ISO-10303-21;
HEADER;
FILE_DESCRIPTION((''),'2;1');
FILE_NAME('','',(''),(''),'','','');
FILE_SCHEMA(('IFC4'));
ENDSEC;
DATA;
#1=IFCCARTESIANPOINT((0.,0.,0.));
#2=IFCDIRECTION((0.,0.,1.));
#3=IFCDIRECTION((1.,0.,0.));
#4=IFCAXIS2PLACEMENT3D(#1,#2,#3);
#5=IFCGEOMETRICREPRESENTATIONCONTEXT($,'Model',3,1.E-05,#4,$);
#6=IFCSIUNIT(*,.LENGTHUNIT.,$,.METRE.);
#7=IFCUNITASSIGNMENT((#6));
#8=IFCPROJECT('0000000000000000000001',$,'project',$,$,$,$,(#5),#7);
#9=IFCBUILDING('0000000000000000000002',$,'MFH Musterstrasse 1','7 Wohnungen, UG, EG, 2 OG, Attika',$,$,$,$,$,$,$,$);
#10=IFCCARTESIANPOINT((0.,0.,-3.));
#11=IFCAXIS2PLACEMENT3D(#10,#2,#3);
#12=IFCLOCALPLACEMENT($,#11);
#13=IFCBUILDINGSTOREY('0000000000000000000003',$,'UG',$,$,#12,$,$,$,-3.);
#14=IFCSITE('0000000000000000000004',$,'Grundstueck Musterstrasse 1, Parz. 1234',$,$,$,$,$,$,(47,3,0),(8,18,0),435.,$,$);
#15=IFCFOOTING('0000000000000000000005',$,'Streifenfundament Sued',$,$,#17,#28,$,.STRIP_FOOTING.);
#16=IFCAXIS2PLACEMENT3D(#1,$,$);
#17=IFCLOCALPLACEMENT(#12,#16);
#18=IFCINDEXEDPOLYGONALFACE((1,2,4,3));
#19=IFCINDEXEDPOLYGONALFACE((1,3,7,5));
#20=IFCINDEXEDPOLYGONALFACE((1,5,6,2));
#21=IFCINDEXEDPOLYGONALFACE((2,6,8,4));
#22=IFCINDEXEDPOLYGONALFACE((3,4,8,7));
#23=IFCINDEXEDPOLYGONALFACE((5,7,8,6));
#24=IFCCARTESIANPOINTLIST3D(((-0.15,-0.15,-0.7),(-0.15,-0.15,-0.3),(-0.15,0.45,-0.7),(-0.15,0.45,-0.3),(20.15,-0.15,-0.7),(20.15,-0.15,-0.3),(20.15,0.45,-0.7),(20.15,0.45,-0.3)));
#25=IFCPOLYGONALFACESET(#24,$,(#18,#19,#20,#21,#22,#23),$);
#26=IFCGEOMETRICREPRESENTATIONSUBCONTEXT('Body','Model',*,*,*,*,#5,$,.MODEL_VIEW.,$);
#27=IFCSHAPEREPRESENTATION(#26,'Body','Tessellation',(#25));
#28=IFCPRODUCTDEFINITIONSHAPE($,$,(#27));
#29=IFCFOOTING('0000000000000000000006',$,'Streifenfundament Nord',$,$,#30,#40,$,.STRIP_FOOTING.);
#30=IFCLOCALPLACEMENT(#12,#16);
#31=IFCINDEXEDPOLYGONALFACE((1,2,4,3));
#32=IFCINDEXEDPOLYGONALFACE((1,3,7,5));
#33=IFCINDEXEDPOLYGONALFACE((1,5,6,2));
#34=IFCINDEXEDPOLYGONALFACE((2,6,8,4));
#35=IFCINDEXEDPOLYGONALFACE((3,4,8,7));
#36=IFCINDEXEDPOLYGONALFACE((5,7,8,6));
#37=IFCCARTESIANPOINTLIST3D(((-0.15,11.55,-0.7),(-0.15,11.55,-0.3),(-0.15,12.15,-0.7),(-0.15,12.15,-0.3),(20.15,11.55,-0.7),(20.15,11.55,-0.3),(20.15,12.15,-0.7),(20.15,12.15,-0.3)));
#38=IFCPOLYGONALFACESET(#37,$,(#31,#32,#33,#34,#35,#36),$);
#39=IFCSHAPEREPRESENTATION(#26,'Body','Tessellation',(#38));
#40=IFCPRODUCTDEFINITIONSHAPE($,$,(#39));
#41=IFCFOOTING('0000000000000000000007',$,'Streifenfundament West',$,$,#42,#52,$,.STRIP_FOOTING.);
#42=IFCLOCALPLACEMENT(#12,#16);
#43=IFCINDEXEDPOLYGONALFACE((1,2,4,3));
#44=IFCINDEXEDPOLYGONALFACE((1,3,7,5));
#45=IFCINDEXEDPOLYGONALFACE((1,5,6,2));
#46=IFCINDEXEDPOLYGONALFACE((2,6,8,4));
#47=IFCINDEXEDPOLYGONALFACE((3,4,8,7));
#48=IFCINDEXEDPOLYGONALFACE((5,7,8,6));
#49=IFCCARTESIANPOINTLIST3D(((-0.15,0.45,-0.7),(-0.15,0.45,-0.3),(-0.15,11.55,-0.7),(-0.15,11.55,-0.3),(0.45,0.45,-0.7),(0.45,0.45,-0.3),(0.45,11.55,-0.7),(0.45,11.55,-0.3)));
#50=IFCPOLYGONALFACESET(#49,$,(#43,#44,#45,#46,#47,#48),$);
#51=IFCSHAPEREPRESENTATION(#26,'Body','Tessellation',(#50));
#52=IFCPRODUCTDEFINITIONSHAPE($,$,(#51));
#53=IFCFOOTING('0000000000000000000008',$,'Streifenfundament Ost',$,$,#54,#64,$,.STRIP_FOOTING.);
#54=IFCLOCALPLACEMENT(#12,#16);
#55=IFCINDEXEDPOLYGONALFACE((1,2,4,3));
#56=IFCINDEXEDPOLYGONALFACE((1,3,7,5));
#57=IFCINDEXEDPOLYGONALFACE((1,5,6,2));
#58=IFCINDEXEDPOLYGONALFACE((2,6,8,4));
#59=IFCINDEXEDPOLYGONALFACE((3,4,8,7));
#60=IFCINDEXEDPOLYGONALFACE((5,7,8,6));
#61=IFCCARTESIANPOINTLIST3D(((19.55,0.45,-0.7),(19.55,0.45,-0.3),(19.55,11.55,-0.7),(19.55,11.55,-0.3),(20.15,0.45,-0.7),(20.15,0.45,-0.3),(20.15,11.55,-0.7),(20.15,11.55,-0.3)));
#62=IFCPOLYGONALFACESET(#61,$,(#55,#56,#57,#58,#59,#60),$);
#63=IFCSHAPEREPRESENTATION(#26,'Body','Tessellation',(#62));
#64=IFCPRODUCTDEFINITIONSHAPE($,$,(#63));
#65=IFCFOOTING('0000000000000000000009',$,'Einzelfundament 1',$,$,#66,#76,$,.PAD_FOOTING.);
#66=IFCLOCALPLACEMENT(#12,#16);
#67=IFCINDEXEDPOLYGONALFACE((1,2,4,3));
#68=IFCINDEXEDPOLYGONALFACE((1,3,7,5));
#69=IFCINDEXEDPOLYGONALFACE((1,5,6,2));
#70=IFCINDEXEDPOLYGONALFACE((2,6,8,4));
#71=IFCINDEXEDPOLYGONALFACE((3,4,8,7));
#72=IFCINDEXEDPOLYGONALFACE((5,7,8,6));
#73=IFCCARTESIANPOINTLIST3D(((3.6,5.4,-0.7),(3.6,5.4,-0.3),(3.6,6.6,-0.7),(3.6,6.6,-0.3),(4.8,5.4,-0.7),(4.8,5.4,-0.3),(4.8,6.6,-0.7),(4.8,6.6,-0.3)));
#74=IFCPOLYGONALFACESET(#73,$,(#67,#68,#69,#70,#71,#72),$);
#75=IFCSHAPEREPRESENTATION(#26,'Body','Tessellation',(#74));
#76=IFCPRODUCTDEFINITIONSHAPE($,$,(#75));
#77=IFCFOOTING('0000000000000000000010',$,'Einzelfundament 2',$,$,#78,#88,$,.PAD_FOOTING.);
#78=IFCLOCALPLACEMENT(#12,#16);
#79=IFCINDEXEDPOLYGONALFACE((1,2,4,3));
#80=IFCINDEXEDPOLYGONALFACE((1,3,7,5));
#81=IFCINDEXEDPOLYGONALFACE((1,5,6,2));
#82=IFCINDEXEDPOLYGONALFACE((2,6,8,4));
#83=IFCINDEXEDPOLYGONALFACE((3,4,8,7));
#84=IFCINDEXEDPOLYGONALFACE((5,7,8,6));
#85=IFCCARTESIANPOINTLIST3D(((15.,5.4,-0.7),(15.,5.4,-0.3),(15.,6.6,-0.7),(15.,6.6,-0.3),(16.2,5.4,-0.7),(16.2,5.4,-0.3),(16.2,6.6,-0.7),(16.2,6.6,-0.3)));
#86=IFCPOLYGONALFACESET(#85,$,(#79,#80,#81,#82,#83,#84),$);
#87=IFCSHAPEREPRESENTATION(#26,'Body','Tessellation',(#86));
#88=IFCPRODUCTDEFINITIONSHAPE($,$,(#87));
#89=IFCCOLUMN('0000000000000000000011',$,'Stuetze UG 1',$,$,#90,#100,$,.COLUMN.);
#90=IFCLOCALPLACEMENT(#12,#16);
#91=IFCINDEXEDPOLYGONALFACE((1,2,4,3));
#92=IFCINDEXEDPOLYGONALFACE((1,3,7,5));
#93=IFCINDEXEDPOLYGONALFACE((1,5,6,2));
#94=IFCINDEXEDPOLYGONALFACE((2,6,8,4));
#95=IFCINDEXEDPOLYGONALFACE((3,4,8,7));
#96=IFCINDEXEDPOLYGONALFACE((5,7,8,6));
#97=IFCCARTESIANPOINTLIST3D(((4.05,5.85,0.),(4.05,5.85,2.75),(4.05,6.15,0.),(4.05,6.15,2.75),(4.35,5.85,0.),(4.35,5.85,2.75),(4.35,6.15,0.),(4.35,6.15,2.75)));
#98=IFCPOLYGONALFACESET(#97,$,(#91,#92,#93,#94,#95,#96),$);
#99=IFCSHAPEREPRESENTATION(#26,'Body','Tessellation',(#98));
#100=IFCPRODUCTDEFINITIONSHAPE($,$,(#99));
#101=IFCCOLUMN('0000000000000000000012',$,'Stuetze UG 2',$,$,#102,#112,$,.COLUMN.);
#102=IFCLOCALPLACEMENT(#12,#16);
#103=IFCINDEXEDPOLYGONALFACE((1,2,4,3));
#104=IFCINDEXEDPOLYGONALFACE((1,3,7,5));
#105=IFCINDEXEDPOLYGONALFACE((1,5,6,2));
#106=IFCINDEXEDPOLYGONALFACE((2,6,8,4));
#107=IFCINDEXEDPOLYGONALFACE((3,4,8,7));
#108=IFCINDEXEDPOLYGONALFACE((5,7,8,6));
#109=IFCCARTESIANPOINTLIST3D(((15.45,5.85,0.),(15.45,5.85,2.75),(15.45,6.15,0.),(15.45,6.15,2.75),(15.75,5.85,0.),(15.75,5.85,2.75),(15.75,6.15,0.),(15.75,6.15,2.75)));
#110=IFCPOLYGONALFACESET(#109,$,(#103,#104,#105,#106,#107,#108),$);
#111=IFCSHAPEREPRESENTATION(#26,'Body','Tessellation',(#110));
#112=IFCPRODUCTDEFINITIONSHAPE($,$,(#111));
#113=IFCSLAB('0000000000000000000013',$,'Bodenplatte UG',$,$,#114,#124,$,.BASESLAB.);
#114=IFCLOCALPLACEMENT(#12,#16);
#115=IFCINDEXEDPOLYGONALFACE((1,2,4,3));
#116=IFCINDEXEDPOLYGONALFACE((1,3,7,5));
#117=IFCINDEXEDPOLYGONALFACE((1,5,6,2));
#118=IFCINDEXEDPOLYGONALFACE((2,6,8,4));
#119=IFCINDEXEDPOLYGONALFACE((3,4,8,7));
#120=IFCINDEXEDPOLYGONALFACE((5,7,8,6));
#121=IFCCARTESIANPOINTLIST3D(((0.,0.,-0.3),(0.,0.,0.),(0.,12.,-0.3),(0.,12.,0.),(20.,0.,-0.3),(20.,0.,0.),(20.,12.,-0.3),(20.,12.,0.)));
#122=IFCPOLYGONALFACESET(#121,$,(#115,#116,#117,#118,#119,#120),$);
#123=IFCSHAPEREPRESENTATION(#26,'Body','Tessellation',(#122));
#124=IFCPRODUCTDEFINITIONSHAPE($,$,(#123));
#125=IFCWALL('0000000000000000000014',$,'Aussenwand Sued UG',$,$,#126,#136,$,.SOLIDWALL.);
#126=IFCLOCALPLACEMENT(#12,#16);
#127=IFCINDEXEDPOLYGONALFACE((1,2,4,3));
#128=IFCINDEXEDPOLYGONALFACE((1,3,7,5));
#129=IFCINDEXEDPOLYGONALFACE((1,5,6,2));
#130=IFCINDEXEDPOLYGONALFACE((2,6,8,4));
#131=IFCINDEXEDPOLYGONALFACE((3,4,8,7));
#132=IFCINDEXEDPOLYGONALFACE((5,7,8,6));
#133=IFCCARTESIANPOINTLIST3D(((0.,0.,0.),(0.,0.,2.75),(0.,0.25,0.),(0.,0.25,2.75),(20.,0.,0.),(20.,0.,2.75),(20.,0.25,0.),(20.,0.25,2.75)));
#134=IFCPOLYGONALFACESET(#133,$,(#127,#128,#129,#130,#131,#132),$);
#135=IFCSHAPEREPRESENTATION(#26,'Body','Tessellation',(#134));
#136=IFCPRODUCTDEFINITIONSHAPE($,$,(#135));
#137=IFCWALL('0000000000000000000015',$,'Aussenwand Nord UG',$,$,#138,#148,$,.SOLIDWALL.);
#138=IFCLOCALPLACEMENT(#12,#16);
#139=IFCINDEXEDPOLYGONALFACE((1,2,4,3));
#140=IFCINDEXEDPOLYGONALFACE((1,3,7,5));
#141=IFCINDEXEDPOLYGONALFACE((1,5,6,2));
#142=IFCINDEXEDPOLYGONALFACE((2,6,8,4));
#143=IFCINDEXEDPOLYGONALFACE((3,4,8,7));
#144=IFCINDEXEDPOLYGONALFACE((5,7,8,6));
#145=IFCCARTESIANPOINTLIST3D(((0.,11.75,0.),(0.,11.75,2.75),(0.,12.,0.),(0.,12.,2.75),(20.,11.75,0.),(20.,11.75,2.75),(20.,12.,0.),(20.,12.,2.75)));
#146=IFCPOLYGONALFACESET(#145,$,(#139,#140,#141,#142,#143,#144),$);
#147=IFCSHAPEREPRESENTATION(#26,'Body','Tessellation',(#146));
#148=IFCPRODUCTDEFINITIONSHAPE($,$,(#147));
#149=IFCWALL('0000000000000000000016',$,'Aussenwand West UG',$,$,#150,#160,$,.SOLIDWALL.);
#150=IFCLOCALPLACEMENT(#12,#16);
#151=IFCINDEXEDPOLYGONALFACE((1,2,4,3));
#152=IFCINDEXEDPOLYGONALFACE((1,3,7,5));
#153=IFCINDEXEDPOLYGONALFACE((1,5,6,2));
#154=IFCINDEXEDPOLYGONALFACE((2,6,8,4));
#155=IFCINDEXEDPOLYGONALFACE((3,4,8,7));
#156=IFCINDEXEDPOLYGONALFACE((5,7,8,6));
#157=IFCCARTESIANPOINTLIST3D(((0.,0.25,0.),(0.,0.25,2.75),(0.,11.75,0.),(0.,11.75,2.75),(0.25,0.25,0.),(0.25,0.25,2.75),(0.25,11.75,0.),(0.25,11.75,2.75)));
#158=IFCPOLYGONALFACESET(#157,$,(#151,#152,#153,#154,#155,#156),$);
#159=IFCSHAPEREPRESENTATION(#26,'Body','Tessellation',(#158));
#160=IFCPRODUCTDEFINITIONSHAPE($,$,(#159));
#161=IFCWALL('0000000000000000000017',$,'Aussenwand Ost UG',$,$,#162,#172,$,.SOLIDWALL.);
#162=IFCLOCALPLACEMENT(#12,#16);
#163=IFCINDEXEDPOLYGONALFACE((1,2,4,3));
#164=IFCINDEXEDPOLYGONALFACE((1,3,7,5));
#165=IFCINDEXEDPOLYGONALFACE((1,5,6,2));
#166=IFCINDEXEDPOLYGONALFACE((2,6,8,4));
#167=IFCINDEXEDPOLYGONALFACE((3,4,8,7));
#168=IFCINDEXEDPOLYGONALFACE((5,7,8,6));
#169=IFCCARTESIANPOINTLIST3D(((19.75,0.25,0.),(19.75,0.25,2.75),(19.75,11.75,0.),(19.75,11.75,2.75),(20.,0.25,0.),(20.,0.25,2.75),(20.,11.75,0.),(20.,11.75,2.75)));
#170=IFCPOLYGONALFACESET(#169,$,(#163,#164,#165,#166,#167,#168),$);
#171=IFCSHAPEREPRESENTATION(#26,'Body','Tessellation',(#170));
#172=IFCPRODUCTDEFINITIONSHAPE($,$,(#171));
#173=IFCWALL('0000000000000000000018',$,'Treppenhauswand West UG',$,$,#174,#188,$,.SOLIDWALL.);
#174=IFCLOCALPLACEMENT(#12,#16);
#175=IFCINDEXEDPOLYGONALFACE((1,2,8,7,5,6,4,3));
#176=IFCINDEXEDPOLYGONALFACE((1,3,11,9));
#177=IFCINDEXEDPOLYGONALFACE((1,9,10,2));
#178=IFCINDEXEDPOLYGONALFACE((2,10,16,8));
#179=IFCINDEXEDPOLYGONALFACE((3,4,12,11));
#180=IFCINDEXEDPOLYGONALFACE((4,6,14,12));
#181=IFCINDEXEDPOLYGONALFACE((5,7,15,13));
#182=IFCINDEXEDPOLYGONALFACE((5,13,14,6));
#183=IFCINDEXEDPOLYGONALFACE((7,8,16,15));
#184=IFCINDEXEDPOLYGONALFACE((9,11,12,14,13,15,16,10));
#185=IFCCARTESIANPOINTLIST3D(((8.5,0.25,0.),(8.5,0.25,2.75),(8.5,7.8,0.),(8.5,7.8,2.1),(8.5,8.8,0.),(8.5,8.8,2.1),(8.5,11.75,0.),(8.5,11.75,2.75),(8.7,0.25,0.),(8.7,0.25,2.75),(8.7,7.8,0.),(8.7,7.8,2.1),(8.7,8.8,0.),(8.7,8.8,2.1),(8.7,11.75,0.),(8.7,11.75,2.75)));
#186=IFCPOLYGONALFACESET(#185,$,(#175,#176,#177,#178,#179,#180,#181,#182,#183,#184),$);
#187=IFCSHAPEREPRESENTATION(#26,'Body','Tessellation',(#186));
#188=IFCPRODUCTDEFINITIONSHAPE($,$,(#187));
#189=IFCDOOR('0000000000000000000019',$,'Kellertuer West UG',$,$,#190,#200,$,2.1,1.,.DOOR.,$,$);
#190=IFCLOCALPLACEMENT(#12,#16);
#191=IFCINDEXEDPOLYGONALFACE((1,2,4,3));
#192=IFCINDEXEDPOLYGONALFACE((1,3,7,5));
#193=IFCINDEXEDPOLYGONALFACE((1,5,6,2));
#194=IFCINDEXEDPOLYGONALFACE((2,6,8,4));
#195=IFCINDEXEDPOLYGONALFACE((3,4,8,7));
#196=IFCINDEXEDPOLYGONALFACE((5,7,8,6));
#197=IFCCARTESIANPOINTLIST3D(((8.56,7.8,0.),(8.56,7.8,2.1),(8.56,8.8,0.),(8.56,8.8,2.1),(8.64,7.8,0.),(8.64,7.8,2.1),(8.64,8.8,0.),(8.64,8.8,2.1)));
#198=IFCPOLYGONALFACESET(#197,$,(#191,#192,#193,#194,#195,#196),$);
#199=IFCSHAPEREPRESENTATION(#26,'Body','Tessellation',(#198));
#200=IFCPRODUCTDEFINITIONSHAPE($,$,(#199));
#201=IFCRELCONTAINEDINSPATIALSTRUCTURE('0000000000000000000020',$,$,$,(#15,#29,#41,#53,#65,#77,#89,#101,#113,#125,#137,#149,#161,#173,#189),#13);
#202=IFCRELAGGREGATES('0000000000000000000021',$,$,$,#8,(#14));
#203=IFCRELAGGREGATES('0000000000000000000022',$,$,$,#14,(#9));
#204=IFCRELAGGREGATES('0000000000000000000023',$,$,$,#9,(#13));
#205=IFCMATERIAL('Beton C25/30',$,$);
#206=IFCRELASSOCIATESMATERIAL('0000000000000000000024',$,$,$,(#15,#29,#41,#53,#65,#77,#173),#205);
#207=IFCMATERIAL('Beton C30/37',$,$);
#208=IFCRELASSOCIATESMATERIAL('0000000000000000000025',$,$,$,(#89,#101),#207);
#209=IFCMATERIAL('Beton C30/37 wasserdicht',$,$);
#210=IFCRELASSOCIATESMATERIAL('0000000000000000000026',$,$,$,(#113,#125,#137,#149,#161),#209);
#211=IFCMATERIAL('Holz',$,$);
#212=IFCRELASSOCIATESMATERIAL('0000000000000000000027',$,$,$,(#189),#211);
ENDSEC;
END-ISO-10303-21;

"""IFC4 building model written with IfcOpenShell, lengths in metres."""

from ifc_helpers import new_model, si_unit, frame, frame_2d, origin_with_axes, place, context, subcontext, project, spatial, polyline, rectangle, outline, extrude, material, element, fill, save


model = new_model("IFC4")

# Units and contexts
model_context = context("Model", 3, precision=1e-05, world=origin_with_axes())
body_context = subcontext(model_context, "Body", "Model", "MODEL_VIEW")
ifc_project = project(units=[si_unit("LENGTHUNIT", "METRE")], contexts=[model_context])

# Site, building, storey
site = spatial("IfcSite", under=ifc_project, Name="Grundstueck Musterstrasse 1, Parz. 1234", RefLatitude=(47, 3, 0), RefLongitude=(8, 18, 0), RefElevation=435.0)
building = spatial("IfcBuilding", under=site, Name="MFH Musterstrasse 1", Description="7 Wohnungen, UG, EG, 2 OG, Attika")
storey_placement = place(None, frame((0.0, 0.0, -3.0), z_axis=(0.0, 0.0, 1.0), x_axis=(1.0, 0.0, 0.0)))
storey = spatial("IfcBuildingStorey", under=building, at=storey_placement, Name="UG", Elevation=-3.0)

# Footings
ifc_material_1 = material(Name="Beton C25/30")
for number, where, z_axis, x_axis, name in (
    (1, (-0.15, -0.15, -0.7), (0.0, 0.0, 1.0), (1.0, 0.0, 0.0), "Streifenfundament Sued"),
    (2, (-0.15, 11.55, -0.7), (0.0, 0.0, 1.0), (1.0, 0.0, 0.0), "Streifenfundament Nord"),
):
    element("IfcFooting", number, at=place(storey_placement, frame(where, z_axis=z_axis, x_axis=x_axis)), inside=storey, material=ifc_material_1, Name=name, PredefinedType="STRIP_FOOTING", context=body_context, shape_type="SweptSolid", body=[
        extrude(rectangle(XDim=20.3, YDim=0.6, at=frame_2d((10.15, 0.3))), origin_with_axes(), (0.0, 0.0, 1.0), 0.4),
    ])
for number, where, z_axis, x_axis, name in (
    (3, (-0.15, 0.45, -0.7), (0.0, 0.0, 1.0), (1.0, 0.0, 0.0), "Streifenfundament West"),
    (4, (19.55, 0.45, -0.7), (0.0, 0.0, 1.0), (1.0, 0.0, 0.0), "Streifenfundament Ost"),
):
    element("IfcFooting", number, at=place(storey_placement, frame(where, z_axis=z_axis, x_axis=x_axis)), inside=storey, material=ifc_material_1, Name=name, PredefinedType="STRIP_FOOTING", context=body_context, shape_type="SweptSolid", body=[
        extrude(rectangle(XDim=0.6, YDim=11.1, at=frame_2d((0.3, 5.55))), origin_with_axes(), (0.0, 0.0, 1.0), 0.4),
    ])
for number, where, z_axis, x_axis, name in (
    (5, (3.6, 5.4, -0.7), (0.0, 0.0, 1.0), (1.0, 0.0, 0.0), "Einzelfundament 1"),
    (6, (15.0, 5.4, -0.7), (0.0, 0.0, 1.0), (1.0, 0.0, 0.0), "Einzelfundament 2"),
):
    element("IfcFooting", number, at=place(storey_placement, frame(where, z_axis=z_axis, x_axis=x_axis)), inside=storey, material=ifc_material_1, Name=name, PredefinedType="PAD_FOOTING", context=body_context, shape_type="SweptSolid", body=[
        extrude(rectangle(XDim=1.2, YDim=1.2, at=frame_2d((0.6, 0.6))), origin_with_axes(), (0.0, 0.0, 1.0), 0.4),
    ])

# Columns
ifc_material_2 = material(Name="Beton C30/37")
for number, where, z_axis, x_axis, name in (
    (7, (4.05, 5.85, 0.0), (0.0, 0.0, 1.0), (1.0, 0.0, 0.0), "Stuetze UG 1"),
    (8, (15.45, 5.85, 0.0), (0.0, 0.0, 1.0), (1.0, 0.0, 0.0), "Stuetze UG 2"),
):
    element("IfcColumn", number, at=place(storey_placement, frame(where, z_axis=z_axis, x_axis=x_axis)), inside=storey, material=ifc_material_2, Name=name, PredefinedType="COLUMN", context=body_context, shape_type="SweptSolid", body=[
        extrude(rectangle(XDim=0.3, YDim=0.3, at=frame_2d((0.15, 0.15))), origin_with_axes(), (0.0, 0.0, 1.0), 2.75),
    ])

# Slab
ifc_material_3 = material(Name="Beton C30/37 wasserdicht")
slab_placement = place(storey_placement, frame((0.0, 0.0, -0.3), z_axis=(0.0, 0.0, 1.0), x_axis=(1.0, 0.0, 0.0)))
element("IfcSlab", 9, at=slab_placement, inside=storey, material=ifc_material_3, Name="Bodenplatte UG", PredefinedType="BASESLAB", context=body_context, shape_type="SweptSolid", body=[
    extrude(outline(polyline([(0.0, 0.0), (20.0, 0.0), (20.0, 12.0), (0.0, 12.0), (0.0, 0.0)])), origin_with_axes(), (0.0, 0.0, 1.0), 0.3),
])

# Walls
for number, where, z_axis, x_axis, name in (
    (10, (0.0, 0.0, 0.0), (0.0, 0.0, 1.0), (1.0, 0.0, 0.0), "Aussenwand Sued UG"),
    (11, (0.0, 11.75, 0.0), (0.0, 0.0, 1.0), (1.0, 0.0, 0.0), "Aussenwand Nord UG"),
):
    element("IfcWall", number, at=place(storey_placement, frame(where, z_axis=z_axis, x_axis=x_axis)), inside=storey, material=ifc_material_3, Name=name, PredefinedType="SOLIDWALL", context=body_context, shape_type="SweptSolid", body=[
        extrude(rectangle(XDim=20.0, YDim=0.25, at=frame_2d((10.0, 0.125))), origin_with_axes(), (0.0, 0.0, 1.0), 2.75),
    ])
for number, where, z_axis, x_axis, name in (
    (12, (0.0, 0.25, 0.0), (0.0, 0.0, 1.0), (1.0, 0.0, 0.0), "Aussenwand West UG"),
    (13, (19.75, 0.25, 0.0), (0.0, 0.0, 1.0), (1.0, 0.0, 0.0), "Aussenwand Ost UG"),
):
    element("IfcWall", number, at=place(storey_placement, frame(where, z_axis=z_axis, x_axis=x_axis)), inside=storey, material=ifc_material_3, Name=name, PredefinedType="SOLIDWALL", context=body_context, shape_type="SweptSolid", body=[
        extrude(rectangle(XDim=0.25, YDim=11.5, at=frame_2d((0.125, 5.75))), origin_with_axes(), (0.0, 0.0, 1.0), 2.75),
    ])

# Wall, opening, door
wall_1_placement = place(storey_placement, frame((8.5, 0.25, 0.0), z_axis=(0.0, 0.0, 1.0), x_axis=(1.0, 0.0, 0.0)))
wall_1 = element("IfcWall", 14, at=wall_1_placement, inside=storey, material=ifc_material_1, Name="Treppenhauswand West UG", PredefinedType="SOLIDWALL", context=body_context, shape_type="SweptSolid", body=[
    extrude(rectangle(XDim=0.2, YDim=11.5, at=frame_2d((0.1, 5.75))), origin_with_axes(), (0.0, 0.0, 1.0), 2.75),
])
opening_1_placement = place(wall_1_placement, frame((-0.01, 7.55, 0.0), z_axis=(0.0, 0.0, 1.0), x_axis=(1.0, 0.0, 0.0)))
opening_1 = element("IfcOpeningElement", 15, at=opening_1_placement, cuts=wall_1, context=body_context, shape_type="SweptSolid", body=[
    extrude(rectangle(XDim=0.22, YDim=1.0, at=frame_2d((0.11, 0.5))), origin_with_axes(), (0.0, 0.0, 1.0), 2.1),
])
ifc_material_4 = material(Name="Holz")
door_1_placement = place(storey_placement, frame((8.56, 7.8, 0.0), z_axis=(0.0, 0.0, 1.0), x_axis=(1.0, 0.0, 0.0)))
door_1 = element("IfcDoor", 16, at=door_1_placement, inside=storey, material=ifc_material_4, Name="Kellertuer West UG", OverallHeight=2.1, OverallWidth=1.0, PredefinedType="DOOR", context=body_context, shape_type="SweptSolid", body=[
    extrude(rectangle(XDim=0.08, YDim=1.0, at=frame_2d((0.04, 0.5))), origin_with_axes(), (0.0, 0.0, 1.0), 2.1),
])
fill(opening_1, door_1)

save(model, "model.ifc")
